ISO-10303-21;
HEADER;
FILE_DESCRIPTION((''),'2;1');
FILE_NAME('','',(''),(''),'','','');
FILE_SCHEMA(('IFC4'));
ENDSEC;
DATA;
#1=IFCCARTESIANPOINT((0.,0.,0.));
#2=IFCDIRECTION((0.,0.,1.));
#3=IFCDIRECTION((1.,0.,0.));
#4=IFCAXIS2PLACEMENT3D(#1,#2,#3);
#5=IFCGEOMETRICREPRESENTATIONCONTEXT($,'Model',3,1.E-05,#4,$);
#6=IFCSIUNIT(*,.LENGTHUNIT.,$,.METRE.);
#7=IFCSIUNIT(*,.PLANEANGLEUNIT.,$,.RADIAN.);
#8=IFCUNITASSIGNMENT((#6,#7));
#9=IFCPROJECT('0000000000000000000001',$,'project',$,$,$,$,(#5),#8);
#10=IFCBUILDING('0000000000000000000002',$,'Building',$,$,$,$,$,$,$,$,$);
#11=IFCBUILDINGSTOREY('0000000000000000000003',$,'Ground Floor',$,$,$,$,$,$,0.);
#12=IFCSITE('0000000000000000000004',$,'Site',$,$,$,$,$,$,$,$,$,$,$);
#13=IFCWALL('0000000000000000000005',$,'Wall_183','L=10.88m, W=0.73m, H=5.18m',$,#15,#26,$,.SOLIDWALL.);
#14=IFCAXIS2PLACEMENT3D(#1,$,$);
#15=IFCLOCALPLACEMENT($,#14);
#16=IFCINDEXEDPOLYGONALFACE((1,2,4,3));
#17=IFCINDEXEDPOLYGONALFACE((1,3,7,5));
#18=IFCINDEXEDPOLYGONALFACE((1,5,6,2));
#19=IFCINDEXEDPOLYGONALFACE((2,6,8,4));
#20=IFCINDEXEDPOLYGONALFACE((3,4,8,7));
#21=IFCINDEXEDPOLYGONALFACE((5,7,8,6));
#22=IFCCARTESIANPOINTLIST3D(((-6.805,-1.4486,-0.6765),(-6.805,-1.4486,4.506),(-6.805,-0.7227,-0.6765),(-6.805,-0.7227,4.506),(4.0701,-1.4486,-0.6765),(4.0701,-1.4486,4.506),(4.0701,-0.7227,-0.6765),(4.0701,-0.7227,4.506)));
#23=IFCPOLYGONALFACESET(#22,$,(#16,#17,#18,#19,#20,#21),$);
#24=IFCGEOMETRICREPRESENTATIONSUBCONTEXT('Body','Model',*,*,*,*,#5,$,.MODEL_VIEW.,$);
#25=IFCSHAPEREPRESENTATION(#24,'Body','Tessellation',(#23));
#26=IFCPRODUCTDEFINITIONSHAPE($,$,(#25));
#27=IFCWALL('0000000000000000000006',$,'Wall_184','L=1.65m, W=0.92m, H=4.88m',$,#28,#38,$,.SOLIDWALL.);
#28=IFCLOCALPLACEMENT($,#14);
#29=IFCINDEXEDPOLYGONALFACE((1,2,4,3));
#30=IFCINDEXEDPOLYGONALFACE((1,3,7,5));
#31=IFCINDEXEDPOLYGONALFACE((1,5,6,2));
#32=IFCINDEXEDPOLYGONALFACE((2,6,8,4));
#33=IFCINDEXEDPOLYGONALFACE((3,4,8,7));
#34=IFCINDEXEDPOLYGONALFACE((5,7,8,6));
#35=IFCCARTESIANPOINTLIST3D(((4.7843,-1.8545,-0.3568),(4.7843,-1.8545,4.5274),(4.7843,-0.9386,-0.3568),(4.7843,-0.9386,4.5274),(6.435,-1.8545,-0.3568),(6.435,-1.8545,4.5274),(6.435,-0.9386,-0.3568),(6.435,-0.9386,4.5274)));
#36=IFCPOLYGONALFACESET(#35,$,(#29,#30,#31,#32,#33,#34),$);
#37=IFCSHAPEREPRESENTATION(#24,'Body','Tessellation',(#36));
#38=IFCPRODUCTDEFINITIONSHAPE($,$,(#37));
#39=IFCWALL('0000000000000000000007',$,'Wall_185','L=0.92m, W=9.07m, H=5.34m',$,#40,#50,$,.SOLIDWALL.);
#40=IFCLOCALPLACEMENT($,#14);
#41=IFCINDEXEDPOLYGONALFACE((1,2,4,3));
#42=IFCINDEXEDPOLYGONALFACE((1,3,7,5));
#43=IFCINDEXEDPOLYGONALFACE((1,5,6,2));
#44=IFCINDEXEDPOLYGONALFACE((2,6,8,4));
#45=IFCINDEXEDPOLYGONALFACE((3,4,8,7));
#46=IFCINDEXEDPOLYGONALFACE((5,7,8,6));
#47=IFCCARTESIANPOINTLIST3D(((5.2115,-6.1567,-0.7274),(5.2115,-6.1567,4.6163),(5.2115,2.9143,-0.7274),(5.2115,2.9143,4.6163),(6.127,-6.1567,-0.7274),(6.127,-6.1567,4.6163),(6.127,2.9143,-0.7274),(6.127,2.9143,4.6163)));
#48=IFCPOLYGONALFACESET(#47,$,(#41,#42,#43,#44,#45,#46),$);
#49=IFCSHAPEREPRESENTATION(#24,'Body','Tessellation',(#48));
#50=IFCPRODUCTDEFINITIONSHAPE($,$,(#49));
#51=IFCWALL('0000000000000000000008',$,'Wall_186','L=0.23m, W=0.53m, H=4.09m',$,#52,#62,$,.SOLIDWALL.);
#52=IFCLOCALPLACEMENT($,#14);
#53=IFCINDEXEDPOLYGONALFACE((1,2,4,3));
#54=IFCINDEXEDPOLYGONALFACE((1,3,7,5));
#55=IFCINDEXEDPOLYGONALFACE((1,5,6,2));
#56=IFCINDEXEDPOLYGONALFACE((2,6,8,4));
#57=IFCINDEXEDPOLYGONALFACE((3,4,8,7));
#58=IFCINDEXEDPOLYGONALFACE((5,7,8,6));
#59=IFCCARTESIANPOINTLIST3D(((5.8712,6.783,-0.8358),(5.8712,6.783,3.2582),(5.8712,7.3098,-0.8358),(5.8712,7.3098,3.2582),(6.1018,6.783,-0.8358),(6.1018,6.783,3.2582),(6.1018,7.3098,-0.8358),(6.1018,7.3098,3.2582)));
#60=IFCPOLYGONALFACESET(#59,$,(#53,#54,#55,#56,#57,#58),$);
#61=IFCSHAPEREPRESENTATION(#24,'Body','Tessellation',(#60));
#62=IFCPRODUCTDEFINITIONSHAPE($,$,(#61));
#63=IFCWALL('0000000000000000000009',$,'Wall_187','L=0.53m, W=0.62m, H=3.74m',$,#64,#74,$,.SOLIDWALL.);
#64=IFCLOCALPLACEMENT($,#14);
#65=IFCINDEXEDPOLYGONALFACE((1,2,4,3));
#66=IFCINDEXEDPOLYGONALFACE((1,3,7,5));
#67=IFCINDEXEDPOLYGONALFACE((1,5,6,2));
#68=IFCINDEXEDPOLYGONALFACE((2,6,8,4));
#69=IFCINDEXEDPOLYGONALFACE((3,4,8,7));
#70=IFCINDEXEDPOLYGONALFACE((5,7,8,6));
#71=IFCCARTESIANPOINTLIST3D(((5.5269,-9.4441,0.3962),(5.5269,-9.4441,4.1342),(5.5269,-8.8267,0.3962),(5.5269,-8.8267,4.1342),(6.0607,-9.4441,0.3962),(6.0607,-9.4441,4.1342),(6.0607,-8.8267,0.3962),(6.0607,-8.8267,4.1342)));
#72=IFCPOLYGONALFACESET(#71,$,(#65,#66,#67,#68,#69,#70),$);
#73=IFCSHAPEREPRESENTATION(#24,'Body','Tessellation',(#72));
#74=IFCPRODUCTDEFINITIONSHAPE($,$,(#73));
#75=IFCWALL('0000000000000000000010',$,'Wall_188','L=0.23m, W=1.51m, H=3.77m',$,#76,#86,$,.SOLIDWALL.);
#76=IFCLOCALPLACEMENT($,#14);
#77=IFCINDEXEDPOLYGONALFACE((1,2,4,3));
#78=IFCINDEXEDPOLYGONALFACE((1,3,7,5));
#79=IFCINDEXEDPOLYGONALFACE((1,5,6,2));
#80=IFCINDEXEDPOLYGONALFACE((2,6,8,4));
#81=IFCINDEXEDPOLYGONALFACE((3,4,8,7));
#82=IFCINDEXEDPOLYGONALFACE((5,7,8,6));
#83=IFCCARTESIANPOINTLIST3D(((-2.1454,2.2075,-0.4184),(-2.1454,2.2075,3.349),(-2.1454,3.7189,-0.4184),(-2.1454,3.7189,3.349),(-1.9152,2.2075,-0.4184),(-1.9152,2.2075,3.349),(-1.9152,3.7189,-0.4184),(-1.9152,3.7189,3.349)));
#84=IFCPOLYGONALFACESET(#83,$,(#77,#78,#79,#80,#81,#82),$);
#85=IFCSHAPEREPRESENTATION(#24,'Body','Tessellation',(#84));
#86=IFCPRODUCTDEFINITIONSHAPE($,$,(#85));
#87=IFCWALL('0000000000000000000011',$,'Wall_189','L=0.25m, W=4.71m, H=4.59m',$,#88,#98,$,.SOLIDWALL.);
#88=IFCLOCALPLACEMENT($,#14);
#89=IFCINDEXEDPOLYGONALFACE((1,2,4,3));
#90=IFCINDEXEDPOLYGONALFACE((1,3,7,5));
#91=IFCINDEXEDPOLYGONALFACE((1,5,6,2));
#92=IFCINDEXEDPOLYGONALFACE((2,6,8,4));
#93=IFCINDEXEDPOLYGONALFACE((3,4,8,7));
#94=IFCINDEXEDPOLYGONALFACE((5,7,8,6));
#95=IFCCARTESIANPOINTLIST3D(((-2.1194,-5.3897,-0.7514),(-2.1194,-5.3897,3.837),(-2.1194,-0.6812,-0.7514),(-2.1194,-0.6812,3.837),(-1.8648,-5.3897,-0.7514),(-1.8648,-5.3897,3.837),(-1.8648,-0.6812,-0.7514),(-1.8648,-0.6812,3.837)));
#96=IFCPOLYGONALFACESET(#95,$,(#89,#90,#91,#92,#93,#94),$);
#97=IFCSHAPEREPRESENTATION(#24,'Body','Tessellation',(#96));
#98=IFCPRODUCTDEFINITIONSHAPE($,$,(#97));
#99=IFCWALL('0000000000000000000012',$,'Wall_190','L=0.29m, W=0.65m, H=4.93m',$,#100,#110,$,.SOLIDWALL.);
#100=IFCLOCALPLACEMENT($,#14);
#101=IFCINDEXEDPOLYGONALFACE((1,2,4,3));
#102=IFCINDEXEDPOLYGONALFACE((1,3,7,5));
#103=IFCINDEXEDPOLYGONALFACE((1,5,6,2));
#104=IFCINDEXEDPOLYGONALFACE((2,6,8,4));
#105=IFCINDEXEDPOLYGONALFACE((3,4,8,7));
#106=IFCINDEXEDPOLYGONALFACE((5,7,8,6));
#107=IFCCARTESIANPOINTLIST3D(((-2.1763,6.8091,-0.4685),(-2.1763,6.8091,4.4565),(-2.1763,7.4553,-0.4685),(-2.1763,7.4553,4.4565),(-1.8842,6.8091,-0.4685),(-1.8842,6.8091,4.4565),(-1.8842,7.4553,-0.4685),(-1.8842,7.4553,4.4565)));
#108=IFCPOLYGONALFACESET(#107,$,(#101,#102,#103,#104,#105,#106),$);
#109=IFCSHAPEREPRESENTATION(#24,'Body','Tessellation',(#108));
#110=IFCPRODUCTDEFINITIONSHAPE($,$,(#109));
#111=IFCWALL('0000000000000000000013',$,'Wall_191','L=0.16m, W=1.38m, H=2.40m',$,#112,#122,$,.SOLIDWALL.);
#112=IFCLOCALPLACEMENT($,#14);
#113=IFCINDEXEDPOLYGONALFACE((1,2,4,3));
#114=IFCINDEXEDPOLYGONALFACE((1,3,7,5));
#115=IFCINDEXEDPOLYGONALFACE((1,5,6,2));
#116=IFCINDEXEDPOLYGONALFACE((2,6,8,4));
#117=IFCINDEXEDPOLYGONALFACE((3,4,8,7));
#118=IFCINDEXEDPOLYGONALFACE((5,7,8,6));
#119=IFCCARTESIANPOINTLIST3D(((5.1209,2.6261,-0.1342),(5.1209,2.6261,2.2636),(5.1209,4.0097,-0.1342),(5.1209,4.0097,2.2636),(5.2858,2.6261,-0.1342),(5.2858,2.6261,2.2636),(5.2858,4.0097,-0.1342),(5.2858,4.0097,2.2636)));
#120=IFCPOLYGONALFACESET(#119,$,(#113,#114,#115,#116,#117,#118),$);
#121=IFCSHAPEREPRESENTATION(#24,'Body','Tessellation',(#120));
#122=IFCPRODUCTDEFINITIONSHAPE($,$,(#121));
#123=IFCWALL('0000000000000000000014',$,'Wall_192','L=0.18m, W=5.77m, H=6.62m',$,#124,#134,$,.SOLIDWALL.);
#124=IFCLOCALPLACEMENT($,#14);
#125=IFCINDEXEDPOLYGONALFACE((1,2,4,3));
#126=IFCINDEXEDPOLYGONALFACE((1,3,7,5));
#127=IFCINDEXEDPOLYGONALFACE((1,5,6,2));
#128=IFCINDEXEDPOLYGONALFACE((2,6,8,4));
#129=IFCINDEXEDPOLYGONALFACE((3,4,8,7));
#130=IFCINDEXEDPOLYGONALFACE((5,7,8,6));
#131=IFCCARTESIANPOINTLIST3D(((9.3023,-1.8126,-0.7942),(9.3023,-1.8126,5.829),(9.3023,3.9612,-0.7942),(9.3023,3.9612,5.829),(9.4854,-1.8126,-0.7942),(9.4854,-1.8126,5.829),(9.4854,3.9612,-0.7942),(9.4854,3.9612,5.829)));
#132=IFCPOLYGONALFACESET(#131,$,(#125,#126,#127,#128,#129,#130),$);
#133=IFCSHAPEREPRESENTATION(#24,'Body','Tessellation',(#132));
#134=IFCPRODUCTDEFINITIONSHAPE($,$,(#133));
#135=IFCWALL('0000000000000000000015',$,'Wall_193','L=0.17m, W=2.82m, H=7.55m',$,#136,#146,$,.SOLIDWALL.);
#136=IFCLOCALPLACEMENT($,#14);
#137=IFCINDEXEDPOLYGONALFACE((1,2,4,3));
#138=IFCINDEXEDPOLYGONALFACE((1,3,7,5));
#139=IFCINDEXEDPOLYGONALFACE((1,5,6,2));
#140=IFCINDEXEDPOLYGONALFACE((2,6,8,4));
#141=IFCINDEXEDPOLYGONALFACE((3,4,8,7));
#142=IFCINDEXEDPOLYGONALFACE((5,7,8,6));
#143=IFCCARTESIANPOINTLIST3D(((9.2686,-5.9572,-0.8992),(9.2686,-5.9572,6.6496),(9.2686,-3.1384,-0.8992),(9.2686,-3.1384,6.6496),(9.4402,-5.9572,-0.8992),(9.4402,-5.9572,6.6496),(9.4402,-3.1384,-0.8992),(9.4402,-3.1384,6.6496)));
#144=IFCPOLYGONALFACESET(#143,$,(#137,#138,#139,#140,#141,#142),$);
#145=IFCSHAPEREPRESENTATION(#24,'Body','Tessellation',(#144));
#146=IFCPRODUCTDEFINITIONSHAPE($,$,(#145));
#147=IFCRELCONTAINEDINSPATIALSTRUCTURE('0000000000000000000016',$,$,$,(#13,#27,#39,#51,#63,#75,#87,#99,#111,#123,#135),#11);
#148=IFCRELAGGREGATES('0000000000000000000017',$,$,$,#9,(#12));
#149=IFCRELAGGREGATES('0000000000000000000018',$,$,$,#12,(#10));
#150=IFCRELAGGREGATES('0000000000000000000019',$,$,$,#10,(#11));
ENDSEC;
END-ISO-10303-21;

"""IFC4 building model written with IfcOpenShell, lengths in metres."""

from ifc_helpers import new_model, si_unit, frame, origin_with_axes, origin_2d, context, subcontext, project, spatial, rectangle, extrude, element, save


model = new_model("IFC4")

# Units and contexts
model_context = context("Model", 3, precision=1e-05, world=origin_with_axes())
body_context = subcontext(model_context, "Body", "Model", "MODEL_VIEW")
ifc_project = project(units=[si_unit("LENGTHUNIT", "METRE"), si_unit("PLANEANGLEUNIT", "RADIAN")], contexts=[model_context])

# Site, building, storey
site = spatial("IfcSite", under=ifc_project, Name="Site")
building = spatial("IfcBuilding", under=site, Name="Building")
storey = spatial("IfcBuildingStorey", under=building, Name="Ground Floor", Elevation=0.0)

# Walls
element("IfcWall", 1, inside=storey, Name="Wall_183", Description="L=10.88m, W=0.73m, H=5.18m", PredefinedType="SOLIDWALL", context=body_context, shape_type="SweptSolid", body=[
    extrude(rectangle(XDim=10.8751, YDim=0.726, at=origin_2d()), frame((-1.3675, -1.0857, -0.6765), z_axis=(0.0, 0.0, 1.0), x_axis=(1.0, 0.0, 0.0)), (0.0, 0.0, 1.0), 5.1825),
])
element("IfcWall", 2, inside=storey, Name="Wall_184", Description="L=1.65m, W=0.92m, H=4.88m", PredefinedType="SOLIDWALL", context=body_context, shape_type="SweptSolid", body=[
    extrude(rectangle(XDim=1.6507, YDim=0.9159, at=origin_2d()), frame((5.6097, -1.3965, -0.3568), z_axis=(0.0, 0.0, 1.0), x_axis=(1.0, 0.0, 0.0)), (0.0, 0.0, 1.0), 4.8842),
])
element("IfcWall", 3, inside=storey, Name="Wall_185", Description="L=0.92m, W=9.07m, H=5.34m", PredefinedType="SOLIDWALL", context=body_context, shape_type="SweptSolid", body=[
    extrude(rectangle(XDim=0.9155, YDim=9.071, at=origin_2d()), frame((5.6693, -1.6212, -0.7274), z_axis=(0.0, 0.0, 1.0), x_axis=(1.0, 0.0, 0.0)), (0.0, 0.0, 1.0), 5.3437),
])
element("IfcWall", 4, inside=storey, Name="Wall_186", Description="L=0.23m, W=0.53m, H=4.09m", PredefinedType="SOLIDWALL", context=body_context, shape_type="SweptSolid", body=[
    extrude(rectangle(XDim=0.2306, YDim=0.5269, at=origin_2d()), frame((5.9865, 7.0464, -0.8358), z_axis=(0.0, 0.0, 1.0), x_axis=(1.0, 0.0, 0.0)), (0.0, 0.0, 1.0), 4.0939),
])
element("IfcWall", 5, inside=storey, Name="Wall_187", Description="L=0.53m, W=0.62m, H=3.74m", PredefinedType="SOLIDWALL", context=body_context, shape_type="SweptSolid", body=[
    extrude(rectangle(XDim=0.5338, YDim=0.6175, at=origin_2d()), frame((5.7938, -9.1354, 0.3962), z_axis=(0.0, 0.0, 1.0), x_axis=(1.0, 0.0, 0.0)), (0.0, 0.0, 1.0), 3.738),
])
element("IfcWall", 6, inside=storey, Name="Wall_188", Description="L=0.23m, W=1.51m, H=3.77m", PredefinedType="SOLIDWALL", context=body_context, shape_type="SweptSolid", body=[
    extrude(rectangle(XDim=0.2303, YDim=1.5114, at=origin_2d()), frame((-2.0303, 2.9632, -0.4184), z_axis=(0.0, 0.0, 1.0), x_axis=(1.0, 0.0, 0.0)), (0.0, 0.0, 1.0), 3.7674),
])
element("IfcWall", 7, inside=storey, Name="Wall_189", Description="L=0.25m, W=4.71m, H=4.59m", PredefinedType="SOLIDWALL", context=body_context, shape_type="SweptSolid", body=[
    extrude(rectangle(XDim=0.2547, YDim=4.7085, at=origin_2d()), frame((-1.9921, -3.0354, -0.7514), z_axis=(0.0, 0.0, 1.0), x_axis=(1.0, 0.0, 0.0)), (0.0, 0.0, 1.0), 4.5884),
])
element("IfcWall", 8, inside=storey, Name="Wall_190", Description="L=0.29m, W=0.65m, H=4.93m", PredefinedType="SOLIDWALL", context=body_context, shape_type="SweptSolid", body=[
    extrude(rectangle(XDim=0.2921, YDim=0.6462, at=origin_2d()), frame((-2.0302, 7.1322, -0.4685), z_axis=(0.0, 0.0, 1.0), x_axis=(1.0, 0.0, 0.0)), (0.0, 0.0, 1.0), 4.925),
])
element("IfcWall", 9, inside=storey, Name="Wall_191", Description="L=0.16m, W=1.38m, H=2.40m", PredefinedType="SOLIDWALL", context=body_context, shape_type="SweptSolid", body=[
    extrude(rectangle(XDim=0.1648, YDim=1.3836, at=origin_2d()), frame((5.2034, 3.3179, -0.1342), z_axis=(0.0, 0.0, 1.0), x_axis=(1.0, 0.0, 0.0)), (0.0, 0.0, 1.0), 2.3978),
])
element("IfcWall", 10, inside=storey, Name="Wall_192", Description="L=0.18m, W=5.77m, H=6.62m", PredefinedType="SOLIDWALL", context=body_context, shape_type="SweptSolid", body=[
    extrude(rectangle(XDim=0.1831, YDim=5.7737, at=origin_2d()), frame((9.3938, 1.0743, -0.7942), z_axis=(0.0, 0.0, 1.0), x_axis=(1.0, 0.0, 0.0)), (0.0, 0.0, 1.0), 6.6232),
])
element("IfcWall", 11, inside=storey, Name="Wall_193", Description="L=0.17m, W=2.82m, H=7.55m", PredefinedType="SOLIDWALL", context=body_context, shape_type="SweptSolid", body=[
    extrude(rectangle(XDim=0.1716, YDim=2.8188, at=origin_2d()), frame((9.3544, -4.5478, -0.8992), z_axis=(0.0, 0.0, 1.0), x_axis=(1.0, 0.0, 0.0)), (0.0, 0.0, 1.0), 7.5489),
])

save(model, "model.ifc")
